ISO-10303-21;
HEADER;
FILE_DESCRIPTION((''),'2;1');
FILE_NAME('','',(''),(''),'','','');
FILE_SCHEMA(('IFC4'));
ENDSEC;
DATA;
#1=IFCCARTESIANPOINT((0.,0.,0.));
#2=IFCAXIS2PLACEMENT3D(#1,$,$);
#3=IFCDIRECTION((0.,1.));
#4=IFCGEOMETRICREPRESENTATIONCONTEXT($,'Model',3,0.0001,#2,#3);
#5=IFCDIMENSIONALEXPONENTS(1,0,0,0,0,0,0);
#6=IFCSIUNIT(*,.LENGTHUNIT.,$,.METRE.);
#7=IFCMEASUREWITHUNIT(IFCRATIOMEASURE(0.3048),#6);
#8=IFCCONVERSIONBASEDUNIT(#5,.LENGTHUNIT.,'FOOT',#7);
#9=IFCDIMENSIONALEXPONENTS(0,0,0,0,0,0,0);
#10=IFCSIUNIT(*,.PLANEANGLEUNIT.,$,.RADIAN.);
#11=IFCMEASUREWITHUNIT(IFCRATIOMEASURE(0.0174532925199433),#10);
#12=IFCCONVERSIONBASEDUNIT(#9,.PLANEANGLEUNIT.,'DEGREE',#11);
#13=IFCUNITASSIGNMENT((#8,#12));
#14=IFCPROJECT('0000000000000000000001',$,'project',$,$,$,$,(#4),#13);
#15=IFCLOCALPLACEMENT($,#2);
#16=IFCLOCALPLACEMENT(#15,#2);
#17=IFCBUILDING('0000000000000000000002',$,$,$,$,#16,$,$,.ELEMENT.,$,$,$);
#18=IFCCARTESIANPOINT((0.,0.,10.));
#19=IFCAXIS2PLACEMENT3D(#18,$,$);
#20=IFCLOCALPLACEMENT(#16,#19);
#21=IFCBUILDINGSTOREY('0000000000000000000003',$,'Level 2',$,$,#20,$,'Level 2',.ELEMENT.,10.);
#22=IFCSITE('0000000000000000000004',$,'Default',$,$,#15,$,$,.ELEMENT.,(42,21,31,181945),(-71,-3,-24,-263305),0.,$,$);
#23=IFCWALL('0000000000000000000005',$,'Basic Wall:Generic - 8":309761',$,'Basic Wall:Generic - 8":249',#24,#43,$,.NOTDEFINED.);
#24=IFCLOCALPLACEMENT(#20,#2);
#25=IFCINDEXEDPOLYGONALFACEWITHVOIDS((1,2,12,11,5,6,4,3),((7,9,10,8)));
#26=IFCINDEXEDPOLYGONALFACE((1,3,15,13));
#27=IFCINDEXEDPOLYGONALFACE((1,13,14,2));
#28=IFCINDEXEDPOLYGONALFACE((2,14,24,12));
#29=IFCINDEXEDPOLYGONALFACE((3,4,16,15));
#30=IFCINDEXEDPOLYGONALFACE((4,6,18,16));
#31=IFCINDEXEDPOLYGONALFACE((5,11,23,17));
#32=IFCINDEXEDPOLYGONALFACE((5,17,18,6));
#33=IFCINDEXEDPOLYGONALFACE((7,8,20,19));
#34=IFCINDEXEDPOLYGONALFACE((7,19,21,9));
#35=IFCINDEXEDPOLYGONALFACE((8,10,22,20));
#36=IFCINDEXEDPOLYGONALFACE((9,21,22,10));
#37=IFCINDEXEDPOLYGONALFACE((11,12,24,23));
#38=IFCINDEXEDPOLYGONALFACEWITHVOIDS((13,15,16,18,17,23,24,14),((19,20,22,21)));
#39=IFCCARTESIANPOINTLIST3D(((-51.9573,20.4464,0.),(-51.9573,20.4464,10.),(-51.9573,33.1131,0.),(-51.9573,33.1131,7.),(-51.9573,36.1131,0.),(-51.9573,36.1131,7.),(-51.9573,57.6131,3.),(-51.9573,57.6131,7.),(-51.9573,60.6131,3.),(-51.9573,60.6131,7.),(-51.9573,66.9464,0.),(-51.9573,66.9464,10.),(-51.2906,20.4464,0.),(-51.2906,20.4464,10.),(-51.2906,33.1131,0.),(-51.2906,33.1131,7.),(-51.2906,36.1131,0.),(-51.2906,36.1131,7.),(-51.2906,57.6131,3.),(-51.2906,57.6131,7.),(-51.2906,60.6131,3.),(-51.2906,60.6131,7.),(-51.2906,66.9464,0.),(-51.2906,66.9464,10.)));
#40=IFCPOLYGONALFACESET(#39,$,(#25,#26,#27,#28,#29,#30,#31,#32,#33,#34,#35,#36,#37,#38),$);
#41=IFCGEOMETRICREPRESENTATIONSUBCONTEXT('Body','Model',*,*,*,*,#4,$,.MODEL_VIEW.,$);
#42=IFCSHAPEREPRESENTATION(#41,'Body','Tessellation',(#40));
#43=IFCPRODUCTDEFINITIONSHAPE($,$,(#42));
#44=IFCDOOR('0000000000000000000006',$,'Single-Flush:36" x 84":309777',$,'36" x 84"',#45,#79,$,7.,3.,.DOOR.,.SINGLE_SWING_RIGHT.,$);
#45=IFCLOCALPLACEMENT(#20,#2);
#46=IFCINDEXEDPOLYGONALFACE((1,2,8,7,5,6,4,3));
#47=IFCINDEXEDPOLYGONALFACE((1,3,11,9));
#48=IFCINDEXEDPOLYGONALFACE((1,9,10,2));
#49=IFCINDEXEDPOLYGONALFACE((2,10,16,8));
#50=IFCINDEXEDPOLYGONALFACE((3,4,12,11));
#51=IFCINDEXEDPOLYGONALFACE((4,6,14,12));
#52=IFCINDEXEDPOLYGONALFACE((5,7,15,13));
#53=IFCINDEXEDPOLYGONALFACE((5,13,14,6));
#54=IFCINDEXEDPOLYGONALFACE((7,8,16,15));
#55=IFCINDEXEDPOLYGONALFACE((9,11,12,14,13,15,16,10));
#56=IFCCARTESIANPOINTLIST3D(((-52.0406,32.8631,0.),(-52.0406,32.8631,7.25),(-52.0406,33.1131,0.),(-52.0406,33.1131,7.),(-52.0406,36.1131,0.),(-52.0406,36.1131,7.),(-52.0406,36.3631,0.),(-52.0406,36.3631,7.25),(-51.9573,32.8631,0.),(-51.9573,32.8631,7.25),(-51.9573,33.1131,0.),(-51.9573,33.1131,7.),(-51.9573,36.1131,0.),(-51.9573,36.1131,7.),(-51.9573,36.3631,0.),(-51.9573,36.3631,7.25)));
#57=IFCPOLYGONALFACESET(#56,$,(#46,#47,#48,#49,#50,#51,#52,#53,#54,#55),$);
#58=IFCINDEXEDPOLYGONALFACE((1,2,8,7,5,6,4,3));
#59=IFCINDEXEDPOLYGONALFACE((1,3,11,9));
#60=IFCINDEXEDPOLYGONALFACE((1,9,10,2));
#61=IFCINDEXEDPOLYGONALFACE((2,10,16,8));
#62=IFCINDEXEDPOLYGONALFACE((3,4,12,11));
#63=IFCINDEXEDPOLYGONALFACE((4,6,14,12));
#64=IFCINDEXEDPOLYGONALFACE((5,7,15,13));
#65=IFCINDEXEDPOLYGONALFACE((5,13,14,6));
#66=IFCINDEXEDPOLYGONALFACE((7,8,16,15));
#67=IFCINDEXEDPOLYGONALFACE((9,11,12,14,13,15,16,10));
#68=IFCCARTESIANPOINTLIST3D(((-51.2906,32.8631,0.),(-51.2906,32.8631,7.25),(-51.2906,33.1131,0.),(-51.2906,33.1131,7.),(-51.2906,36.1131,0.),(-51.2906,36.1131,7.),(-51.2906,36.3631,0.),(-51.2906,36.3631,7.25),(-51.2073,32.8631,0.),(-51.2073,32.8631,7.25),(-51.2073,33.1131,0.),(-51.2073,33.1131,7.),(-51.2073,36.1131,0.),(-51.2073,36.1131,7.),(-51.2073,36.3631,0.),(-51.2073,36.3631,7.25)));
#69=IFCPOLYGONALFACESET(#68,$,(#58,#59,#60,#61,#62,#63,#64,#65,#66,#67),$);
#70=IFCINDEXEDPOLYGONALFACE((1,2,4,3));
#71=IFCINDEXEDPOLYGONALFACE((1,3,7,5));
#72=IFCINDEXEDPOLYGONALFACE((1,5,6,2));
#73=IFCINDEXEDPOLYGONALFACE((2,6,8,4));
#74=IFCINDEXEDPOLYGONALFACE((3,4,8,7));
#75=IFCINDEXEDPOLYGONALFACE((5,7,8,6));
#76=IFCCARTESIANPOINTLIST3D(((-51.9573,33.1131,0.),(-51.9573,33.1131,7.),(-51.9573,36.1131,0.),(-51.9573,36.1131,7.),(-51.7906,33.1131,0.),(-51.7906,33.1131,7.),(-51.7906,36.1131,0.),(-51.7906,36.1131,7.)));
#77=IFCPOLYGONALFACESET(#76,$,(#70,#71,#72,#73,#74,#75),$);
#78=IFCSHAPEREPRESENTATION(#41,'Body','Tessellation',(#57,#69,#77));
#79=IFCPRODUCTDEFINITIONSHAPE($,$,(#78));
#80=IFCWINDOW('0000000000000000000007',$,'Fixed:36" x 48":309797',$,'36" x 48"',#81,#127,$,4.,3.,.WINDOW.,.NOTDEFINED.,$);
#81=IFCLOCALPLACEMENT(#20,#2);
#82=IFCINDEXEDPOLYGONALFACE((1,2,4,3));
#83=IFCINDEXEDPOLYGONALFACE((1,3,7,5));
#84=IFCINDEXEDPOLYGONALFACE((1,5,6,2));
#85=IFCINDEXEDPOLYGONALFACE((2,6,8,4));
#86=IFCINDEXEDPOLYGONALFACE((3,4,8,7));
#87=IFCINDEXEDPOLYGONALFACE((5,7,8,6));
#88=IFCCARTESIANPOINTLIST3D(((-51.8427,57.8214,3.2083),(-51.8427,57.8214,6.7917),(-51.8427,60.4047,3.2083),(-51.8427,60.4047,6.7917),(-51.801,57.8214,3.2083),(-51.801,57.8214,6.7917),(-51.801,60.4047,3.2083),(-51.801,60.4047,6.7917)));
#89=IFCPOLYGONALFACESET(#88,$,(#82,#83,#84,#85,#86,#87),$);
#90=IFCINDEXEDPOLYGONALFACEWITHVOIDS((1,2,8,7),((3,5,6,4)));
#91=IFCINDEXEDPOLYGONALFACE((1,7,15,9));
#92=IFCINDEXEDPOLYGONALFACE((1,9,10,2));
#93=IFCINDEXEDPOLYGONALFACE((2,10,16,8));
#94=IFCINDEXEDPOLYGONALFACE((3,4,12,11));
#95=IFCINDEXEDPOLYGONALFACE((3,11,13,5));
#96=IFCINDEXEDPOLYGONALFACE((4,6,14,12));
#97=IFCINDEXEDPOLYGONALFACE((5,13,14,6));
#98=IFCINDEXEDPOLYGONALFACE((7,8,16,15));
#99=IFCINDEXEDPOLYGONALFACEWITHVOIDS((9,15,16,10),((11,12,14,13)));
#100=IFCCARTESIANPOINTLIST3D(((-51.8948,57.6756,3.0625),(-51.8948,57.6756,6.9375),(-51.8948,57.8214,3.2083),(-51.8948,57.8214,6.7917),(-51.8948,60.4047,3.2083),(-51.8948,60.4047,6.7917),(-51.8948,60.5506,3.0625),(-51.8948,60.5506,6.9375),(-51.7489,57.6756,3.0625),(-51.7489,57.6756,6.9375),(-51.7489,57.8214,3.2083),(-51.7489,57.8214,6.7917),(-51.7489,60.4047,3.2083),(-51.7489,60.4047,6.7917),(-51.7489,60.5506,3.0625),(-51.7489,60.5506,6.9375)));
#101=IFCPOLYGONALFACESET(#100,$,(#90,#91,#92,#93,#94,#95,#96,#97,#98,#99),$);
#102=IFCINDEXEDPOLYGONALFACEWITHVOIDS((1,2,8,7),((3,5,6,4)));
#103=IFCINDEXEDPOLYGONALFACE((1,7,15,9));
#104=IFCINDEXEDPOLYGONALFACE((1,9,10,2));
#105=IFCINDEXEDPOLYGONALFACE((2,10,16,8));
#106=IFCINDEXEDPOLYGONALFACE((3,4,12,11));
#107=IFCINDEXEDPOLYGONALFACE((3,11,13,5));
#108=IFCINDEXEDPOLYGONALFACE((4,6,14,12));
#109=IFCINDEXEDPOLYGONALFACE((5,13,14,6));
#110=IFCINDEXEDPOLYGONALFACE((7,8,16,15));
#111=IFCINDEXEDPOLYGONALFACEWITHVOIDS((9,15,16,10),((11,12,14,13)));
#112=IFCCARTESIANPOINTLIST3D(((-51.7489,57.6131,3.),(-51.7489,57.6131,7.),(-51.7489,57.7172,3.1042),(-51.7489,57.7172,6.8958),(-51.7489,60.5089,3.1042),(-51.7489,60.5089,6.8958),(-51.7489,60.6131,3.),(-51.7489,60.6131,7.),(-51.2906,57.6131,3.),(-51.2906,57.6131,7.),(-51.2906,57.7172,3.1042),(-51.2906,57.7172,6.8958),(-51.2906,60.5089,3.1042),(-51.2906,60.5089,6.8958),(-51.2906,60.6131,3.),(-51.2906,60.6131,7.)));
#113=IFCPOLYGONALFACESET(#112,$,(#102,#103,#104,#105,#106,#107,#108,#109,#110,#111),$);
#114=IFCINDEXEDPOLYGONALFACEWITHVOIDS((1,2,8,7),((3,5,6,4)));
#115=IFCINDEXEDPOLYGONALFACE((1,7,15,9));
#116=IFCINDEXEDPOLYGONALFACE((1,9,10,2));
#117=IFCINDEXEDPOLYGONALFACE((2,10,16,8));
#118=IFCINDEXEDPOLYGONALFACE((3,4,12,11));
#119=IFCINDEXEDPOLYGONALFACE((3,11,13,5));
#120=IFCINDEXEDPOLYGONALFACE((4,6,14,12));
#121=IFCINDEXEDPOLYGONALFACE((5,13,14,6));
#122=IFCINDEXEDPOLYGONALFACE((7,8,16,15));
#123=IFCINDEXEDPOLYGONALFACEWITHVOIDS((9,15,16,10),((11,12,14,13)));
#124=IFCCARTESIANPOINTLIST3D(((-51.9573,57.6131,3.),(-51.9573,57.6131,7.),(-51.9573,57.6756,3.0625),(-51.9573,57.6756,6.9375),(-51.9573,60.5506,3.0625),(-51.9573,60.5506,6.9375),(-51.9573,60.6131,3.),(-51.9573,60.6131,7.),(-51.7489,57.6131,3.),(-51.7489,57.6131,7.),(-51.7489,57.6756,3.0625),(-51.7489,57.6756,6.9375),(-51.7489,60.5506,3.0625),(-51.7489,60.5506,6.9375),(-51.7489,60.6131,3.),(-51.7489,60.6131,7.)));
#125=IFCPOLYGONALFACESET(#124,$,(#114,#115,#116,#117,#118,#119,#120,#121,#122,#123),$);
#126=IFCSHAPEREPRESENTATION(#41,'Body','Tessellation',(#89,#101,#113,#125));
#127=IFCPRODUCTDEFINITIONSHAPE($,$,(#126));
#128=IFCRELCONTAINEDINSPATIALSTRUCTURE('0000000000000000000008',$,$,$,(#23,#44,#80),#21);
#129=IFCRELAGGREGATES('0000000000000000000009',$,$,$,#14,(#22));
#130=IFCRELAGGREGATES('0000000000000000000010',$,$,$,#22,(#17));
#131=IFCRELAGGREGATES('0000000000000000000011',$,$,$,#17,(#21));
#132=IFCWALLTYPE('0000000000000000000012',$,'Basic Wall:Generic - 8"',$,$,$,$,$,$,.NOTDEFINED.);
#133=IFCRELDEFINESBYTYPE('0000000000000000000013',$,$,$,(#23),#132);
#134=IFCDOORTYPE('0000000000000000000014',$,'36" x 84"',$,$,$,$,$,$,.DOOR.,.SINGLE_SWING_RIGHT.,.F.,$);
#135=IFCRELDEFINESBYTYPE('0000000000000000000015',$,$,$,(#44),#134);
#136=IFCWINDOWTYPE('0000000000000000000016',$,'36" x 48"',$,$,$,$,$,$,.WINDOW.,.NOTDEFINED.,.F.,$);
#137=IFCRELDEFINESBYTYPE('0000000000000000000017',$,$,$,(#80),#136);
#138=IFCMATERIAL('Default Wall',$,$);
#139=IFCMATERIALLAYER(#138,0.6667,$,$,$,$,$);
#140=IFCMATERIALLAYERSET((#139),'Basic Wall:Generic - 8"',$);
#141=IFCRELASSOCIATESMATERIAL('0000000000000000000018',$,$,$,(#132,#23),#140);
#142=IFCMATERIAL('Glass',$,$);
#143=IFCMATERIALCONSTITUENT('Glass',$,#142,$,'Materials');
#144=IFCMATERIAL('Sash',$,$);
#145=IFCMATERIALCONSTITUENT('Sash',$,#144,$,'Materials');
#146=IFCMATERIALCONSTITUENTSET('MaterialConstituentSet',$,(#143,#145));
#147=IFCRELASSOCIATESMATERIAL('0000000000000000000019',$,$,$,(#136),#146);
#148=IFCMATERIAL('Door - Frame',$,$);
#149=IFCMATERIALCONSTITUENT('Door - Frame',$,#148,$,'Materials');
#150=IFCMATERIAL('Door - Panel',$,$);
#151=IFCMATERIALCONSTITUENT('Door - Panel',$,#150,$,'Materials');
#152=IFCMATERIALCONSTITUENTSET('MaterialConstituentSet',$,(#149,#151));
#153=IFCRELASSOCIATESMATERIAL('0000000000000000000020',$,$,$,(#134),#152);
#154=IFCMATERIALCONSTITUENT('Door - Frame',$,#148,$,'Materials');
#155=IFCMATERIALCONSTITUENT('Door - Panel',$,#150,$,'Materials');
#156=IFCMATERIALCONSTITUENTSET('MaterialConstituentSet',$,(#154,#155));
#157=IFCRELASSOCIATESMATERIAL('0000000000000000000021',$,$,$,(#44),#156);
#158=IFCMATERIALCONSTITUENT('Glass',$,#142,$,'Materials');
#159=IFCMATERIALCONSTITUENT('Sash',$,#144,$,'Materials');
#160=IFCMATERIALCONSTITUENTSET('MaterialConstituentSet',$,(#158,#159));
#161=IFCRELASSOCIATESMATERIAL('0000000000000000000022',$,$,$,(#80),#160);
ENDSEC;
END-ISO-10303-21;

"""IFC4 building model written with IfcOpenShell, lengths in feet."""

from ifc_helpers import new_model, entity, si_unit, converted_unit, direction, frame, frame_2d, origin, place, context, subcontext, project, spatial, polyline, rectangle, outline, extrude, source, transform, mapped, material, layer, layer_set, layer_usage, constituent, constituent_set, type_object, type_shapes, element, fill, save


model = new_model("IFC4")

# Units and contexts
model_context = context("Model", 3, precision=0.0001, world=origin(), true_north=direction((0.0, 1.0)))
body_context = subcontext(model_context, "Body", "Model", "MODEL_VIEW")
ifc_project = project(units=[converted_unit("LENGTHUNIT", "FOOT", entity("IfcRatioMeasure", 0.3048), si_unit("LENGTHUNIT", "METRE"), dimensions=[1, 0, 0, 0, 0, 0, 0]), converted_unit("PLANEANGLEUNIT", "DEGREE", entity("IfcRatioMeasure", 0.0174532925199433), si_unit("PLANEANGLEUNIT", "RADIAN"), dimensions=[0, 0, 0, 0, 0, 0, 0])], contexts=[model_context])

# Site, building, storey
site_placement = place(None, origin())
site = spatial("IfcSite", under=ifc_project, at=site_placement, Name="Default", CompositionType="ELEMENT", RefLatitude=(42, 21, 31, 181945), RefLongitude=(-71, -3, -24, -263305), RefElevation=0.0)
building_placement = place(site_placement, origin())
building = spatial("IfcBuilding", under=site, at=building_placement, CompositionType="ELEMENT")
storey_placement = place(building_placement, frame((0.0, 0.0, 10.0)))
storey = spatial("IfcBuildingStorey", under=building, at=storey_placement, Name="Level 2", LongName="Level 2", CompositionType="ELEMENT", Elevation=10.0)

# Shared definitions
ifc_material_1 = material(Name="Default Wall")
ifc_layer = layer(ifc_material_1, 0.6667)
ifc_layer_set = layer_set([ifc_layer], Name="Basic Wall:Generic - 8\"")
wall_type = type_object("IfcWallType", Name="Basic Wall:Generic - 8\"", PredefinedType="NOTDEFINED", material=ifc_layer_set)
ifc_material_2 = material(Name="Glass")
ifc_material_3 = material(Name="Sash")
ifc_constituent_1 = constituent(ifc_material_2, Name="Glass", Category="Materials")
ifc_constituent_2 = constituent(ifc_material_3, Name="Sash", Category="Materials")
ifc_constituent_set_1 = constituent_set(constituents=[ifc_constituent_1, ifc_constituent_2], Name="MaterialConstituentSet")
window_type_1 = type_object("IfcWindowType", Name="36\" x 48\"", ParameterTakesPrecedence=False, PartitioningType="NOTDEFINED", PredefinedType="WINDOW", material=ifc_constituent_set_1)
shared_shape_1 = source(origin(), body_context, "Body", "SweptSolid", [
    extrude(rectangle(XDim=0.0417, YDim=2.5833, at=frame_2d((0.0, 0.0), x_axis=(1.0, 0.0))), frame((1.5, 0.5312, 0.2083), z_axis=(0.0, 0.0, 1.0), x_axis=(0.0, 1.0, 0.0)), (0.0, 0.0, 1.0), 3.5833),
    extrude(outline(polyline([(-1.4375, -1.9375), (1.4375, -1.9375), (1.4375, 1.9375), (-1.4375, 1.9375), (-1.4375, -1.9375)]), holes=[polyline([(-1.2917, -1.7917), (-1.2917, 1.7917), (1.2917, 1.7917), (1.2917, -1.7917), (-1.2917, -1.7917)])]), frame((1.5, 0.4583, 2.0), z_axis=(0.0, 1.0, 0.0), x_axis=(1.0, 0.0, 0.0)), (0.0, 0.0, 1.0), 0.1458),
    extrude(outline(polyline([(-1.5, -2.0), (1.5, -2.0), (1.5, 2.0), (-1.5, 2.0), (-1.5, -2.0)]), holes=[polyline([(-1.3958, -1.8958), (-1.3958, 1.8958), (1.3958, 1.8958), (1.3958, -1.8958), (-1.3958, -1.8958)])]), frame((1.5, 0.0, 2.0), z_axis=(0.0, 1.0, 0.0), x_axis=(1.0, 0.0, 0.0)), (0.0, 0.0, 1.0), 0.4583),
    extrude(outline(polyline([(-2.0, -1.5), (2.0, -1.5), (2.0, 1.5), (-2.0, 1.5), (-2.0, -1.5)]), holes=[polyline([(-1.9375, -1.4375), (-1.9375, 1.4375), (1.9375, 1.4375), (1.9375, -1.4375), (-1.9375, -1.4375)])]), frame((1.5, 0.4583, 2.0), z_axis=(0.0, 1.0, 0.0), x_axis=(0.0, 0.0, -1.0)), (0.0, 0.0, 1.0), 0.2083),
])
type_shapes(window_type_1, [shared_shape_1])

# Wall, openings, door, window
ifc_layer_usage_1 = layer_usage(ifc_layer_set, "AXIS2", "NEGATIVE", 0.3333)
wall_1_placement = place(storey_placement, frame((-51.6239, 66.9464, 0.0), z_axis=(0.0, 0.0, 1.0), x_axis=(0.0, -1.0, 0.0)))
wall_1 = element("IfcWall", 1, at=wall_1_placement, inside=storey, type_object=wall_type, material=ifc_layer_usage_1, Name="Basic Wall:Generic - 8\":309761", ObjectType="Basic Wall:Generic - 8\":249", PredefinedType="NOTDEFINED", context=body_context, shape_type="SweptSolid", body=[
    extrude(rectangle(XDim=46.5, YDim=0.6667, at=frame_2d((23.25, 0.0), x_axis=(-1.0, 0.0))), origin(), (0.0, 0.0, 1.0), 10.0),
])
opening_1_placement = place(wall_1_placement, frame((33.8333, 0.3333, 0.0)))
opening_1 = element("IfcOpeningElement", 2, at=opening_1_placement, cuts=wall_1, ObjectType="Opening", PredefinedType="OPENING", context=body_context, shape_type="SweptSolid", body=[
    extrude(rectangle(XDim=3.0, YDim=7.0, at=frame_2d((3.5, 1.5), x_axis=(0.0, 1.0))), frame((0.0, 0.0, 0.0), z_axis=(0.0, -1.0, 0.0), x_axis=(0.0, 0.0, 1.0)), (0.0, 0.0, 1.0), 0.6667),
])
opening_2_placement = place(wall_1_placement, frame((9.3333, 0.3333, 3.0)))
opening_2 = element("IfcOpeningElement", 3, at=opening_2_placement, cuts=wall_1, ObjectType="Opening", PredefinedType="OPENING", context=body_context, shape_type="SweptSolid", body=[
    extrude(rectangle(XDim=4.0, YDim=3.0, at=frame_2d((2.0, 1.5), x_axis=(-1.0, 0.0))), frame((0.0, 0.0, 0.0), z_axis=(0.0, -1.0, 0.0), x_axis=(0.0, 0.0, 1.0)), (0.0, 0.0, 1.0), 0.6667),
])
ifc_material_4 = material(Name="Door - Frame")
ifc_constituent_3 = constituent(ifc_material_4, Name="Door - Frame", Category="Materials")
ifc_material_5 = material(Name="Door - Panel")
ifc_constituent_4 = constituent(ifc_material_5, Name="Door - Panel", Category="Materials")
ifc_constituent_set_2 = constituent_set(constituents=[ifc_constituent_3, ifc_constituent_4], Name="MaterialConstituentSet")
ifc_constituent_5 = constituent(ifc_material_4, Name="Door - Frame", Category="Materials")
ifc_constituent_6 = constituent(ifc_material_5, Name="Door - Panel", Category="Materials")
ifc_constituent_set_3 = constituent_set(constituents=[ifc_constituent_5, ifc_constituent_6], Name="MaterialConstituentSet")
door_type_1 = type_object("IfcDoorType", Name="36\" x 84\"", OperationType="SINGLE_SWING_RIGHT", ParameterTakesPrecedence=False, PredefinedType="DOOR", material=ifc_constituent_set_3)
shared_shape_2 = source(origin(), body_context, "Body", "SweptSolid", [
    extrude(outline(polyline([(-1.75, -3.6875), (1.75, -3.6875), (1.75, 3.5625), (1.5, 3.5625), (1.5, -3.4375), (-1.5, -3.4375), (-1.5, 3.5625), (-1.75, 3.5625), (-1.75, -3.6875)])), frame((1.5, 0.6667, 3.5625), z_axis=(0.0, 1.0, 0.0), x_axis=(1.0, 0.0, 0.0)), (0.0, 0.0, 1.0), 0.0833),
    extrude(outline(polyline([(-3.6875, -1.75), (3.5625, -1.75), (3.5625, -1.5), (-3.4375, -1.5), (-3.4375, 1.5), (3.5625, 1.5), (3.5625, 1.75), (-3.6875, 1.75), (-3.6875, -1.75)])), frame((1.5, -0.0833, 3.5625), z_axis=(0.0, 1.0, 0.0), x_axis=(0.0, 0.0, -1.0)), (0.0, 0.0, 1.0), 0.0833),
    extrude(rectangle(XDim=0.1667, YDim=3.0, at=frame_2d((0.0, 0.0), x_axis=(1.0, 0.0))), frame((1.5, 0.5833, 0.0), z_axis=(0.0, 0.0, 1.0), x_axis=(0.0, 1.0, 0.0)), (0.0, 0.0, 1.0), 7.0),
])
type_shapes(door_type_1, [shared_shape_2])
door_1_placement = place(opening_1_placement, frame((0.0, 0.0, 0.0), z_axis=(0.0, 0.0, 1.0), x_axis=(-1.0, 0.0, 0.0)))
door_1 = element("IfcDoor", 4, at=door_1_placement, inside=storey, type_object=door_type_1, material=ifc_constituent_set_2, Name="Single-Flush:36\" x 84\":309777", ObjectType="36\" x 84\"", OperationType="SINGLE_SWING_RIGHT", OverallHeight=7.0, OverallWidth=3.0, PredefinedType="DOOR", context=body_context, shape_type="MappedRepresentation", body=[
    mapped(shared_shape_2, transform((0.0, 0.0, 0.0), scale=1.0)),
])
fill(opening_1, door_1)
ifc_constituent_7 = constituent(ifc_material_2, Name="Glass", Category="Materials")
ifc_constituent_8 = constituent(ifc_material_3, Name="Sash", Category="Materials")
ifc_constituent_set_4 = constituent_set(constituents=[ifc_constituent_7, ifc_constituent_8], Name="MaterialConstituentSet")
window_1_placement = place(opening_2_placement, frame((0.0, 0.0, 0.0), z_axis=(0.0, 0.0, 1.0), x_axis=(-1.0, 0.0, 0.0)))
window_1 = element("IfcWindow", 5, at=window_1_placement, inside=storey, type_object=window_type_1, material=ifc_constituent_set_4, Name="Fixed:36\" x 48\":309797", ObjectType="36\" x 48\"", OverallHeight=4.0, OverallWidth=3.0, PartitioningType="NOTDEFINED", PredefinedType="WINDOW", context=body_context, shape_type="MappedRepresentation", body=[
    mapped(shared_shape_1, transform((0.0, 0.0, 0.0), scale=1.0)),
])
fill(opening_2, window_1)

save(model, "model.ifc")
